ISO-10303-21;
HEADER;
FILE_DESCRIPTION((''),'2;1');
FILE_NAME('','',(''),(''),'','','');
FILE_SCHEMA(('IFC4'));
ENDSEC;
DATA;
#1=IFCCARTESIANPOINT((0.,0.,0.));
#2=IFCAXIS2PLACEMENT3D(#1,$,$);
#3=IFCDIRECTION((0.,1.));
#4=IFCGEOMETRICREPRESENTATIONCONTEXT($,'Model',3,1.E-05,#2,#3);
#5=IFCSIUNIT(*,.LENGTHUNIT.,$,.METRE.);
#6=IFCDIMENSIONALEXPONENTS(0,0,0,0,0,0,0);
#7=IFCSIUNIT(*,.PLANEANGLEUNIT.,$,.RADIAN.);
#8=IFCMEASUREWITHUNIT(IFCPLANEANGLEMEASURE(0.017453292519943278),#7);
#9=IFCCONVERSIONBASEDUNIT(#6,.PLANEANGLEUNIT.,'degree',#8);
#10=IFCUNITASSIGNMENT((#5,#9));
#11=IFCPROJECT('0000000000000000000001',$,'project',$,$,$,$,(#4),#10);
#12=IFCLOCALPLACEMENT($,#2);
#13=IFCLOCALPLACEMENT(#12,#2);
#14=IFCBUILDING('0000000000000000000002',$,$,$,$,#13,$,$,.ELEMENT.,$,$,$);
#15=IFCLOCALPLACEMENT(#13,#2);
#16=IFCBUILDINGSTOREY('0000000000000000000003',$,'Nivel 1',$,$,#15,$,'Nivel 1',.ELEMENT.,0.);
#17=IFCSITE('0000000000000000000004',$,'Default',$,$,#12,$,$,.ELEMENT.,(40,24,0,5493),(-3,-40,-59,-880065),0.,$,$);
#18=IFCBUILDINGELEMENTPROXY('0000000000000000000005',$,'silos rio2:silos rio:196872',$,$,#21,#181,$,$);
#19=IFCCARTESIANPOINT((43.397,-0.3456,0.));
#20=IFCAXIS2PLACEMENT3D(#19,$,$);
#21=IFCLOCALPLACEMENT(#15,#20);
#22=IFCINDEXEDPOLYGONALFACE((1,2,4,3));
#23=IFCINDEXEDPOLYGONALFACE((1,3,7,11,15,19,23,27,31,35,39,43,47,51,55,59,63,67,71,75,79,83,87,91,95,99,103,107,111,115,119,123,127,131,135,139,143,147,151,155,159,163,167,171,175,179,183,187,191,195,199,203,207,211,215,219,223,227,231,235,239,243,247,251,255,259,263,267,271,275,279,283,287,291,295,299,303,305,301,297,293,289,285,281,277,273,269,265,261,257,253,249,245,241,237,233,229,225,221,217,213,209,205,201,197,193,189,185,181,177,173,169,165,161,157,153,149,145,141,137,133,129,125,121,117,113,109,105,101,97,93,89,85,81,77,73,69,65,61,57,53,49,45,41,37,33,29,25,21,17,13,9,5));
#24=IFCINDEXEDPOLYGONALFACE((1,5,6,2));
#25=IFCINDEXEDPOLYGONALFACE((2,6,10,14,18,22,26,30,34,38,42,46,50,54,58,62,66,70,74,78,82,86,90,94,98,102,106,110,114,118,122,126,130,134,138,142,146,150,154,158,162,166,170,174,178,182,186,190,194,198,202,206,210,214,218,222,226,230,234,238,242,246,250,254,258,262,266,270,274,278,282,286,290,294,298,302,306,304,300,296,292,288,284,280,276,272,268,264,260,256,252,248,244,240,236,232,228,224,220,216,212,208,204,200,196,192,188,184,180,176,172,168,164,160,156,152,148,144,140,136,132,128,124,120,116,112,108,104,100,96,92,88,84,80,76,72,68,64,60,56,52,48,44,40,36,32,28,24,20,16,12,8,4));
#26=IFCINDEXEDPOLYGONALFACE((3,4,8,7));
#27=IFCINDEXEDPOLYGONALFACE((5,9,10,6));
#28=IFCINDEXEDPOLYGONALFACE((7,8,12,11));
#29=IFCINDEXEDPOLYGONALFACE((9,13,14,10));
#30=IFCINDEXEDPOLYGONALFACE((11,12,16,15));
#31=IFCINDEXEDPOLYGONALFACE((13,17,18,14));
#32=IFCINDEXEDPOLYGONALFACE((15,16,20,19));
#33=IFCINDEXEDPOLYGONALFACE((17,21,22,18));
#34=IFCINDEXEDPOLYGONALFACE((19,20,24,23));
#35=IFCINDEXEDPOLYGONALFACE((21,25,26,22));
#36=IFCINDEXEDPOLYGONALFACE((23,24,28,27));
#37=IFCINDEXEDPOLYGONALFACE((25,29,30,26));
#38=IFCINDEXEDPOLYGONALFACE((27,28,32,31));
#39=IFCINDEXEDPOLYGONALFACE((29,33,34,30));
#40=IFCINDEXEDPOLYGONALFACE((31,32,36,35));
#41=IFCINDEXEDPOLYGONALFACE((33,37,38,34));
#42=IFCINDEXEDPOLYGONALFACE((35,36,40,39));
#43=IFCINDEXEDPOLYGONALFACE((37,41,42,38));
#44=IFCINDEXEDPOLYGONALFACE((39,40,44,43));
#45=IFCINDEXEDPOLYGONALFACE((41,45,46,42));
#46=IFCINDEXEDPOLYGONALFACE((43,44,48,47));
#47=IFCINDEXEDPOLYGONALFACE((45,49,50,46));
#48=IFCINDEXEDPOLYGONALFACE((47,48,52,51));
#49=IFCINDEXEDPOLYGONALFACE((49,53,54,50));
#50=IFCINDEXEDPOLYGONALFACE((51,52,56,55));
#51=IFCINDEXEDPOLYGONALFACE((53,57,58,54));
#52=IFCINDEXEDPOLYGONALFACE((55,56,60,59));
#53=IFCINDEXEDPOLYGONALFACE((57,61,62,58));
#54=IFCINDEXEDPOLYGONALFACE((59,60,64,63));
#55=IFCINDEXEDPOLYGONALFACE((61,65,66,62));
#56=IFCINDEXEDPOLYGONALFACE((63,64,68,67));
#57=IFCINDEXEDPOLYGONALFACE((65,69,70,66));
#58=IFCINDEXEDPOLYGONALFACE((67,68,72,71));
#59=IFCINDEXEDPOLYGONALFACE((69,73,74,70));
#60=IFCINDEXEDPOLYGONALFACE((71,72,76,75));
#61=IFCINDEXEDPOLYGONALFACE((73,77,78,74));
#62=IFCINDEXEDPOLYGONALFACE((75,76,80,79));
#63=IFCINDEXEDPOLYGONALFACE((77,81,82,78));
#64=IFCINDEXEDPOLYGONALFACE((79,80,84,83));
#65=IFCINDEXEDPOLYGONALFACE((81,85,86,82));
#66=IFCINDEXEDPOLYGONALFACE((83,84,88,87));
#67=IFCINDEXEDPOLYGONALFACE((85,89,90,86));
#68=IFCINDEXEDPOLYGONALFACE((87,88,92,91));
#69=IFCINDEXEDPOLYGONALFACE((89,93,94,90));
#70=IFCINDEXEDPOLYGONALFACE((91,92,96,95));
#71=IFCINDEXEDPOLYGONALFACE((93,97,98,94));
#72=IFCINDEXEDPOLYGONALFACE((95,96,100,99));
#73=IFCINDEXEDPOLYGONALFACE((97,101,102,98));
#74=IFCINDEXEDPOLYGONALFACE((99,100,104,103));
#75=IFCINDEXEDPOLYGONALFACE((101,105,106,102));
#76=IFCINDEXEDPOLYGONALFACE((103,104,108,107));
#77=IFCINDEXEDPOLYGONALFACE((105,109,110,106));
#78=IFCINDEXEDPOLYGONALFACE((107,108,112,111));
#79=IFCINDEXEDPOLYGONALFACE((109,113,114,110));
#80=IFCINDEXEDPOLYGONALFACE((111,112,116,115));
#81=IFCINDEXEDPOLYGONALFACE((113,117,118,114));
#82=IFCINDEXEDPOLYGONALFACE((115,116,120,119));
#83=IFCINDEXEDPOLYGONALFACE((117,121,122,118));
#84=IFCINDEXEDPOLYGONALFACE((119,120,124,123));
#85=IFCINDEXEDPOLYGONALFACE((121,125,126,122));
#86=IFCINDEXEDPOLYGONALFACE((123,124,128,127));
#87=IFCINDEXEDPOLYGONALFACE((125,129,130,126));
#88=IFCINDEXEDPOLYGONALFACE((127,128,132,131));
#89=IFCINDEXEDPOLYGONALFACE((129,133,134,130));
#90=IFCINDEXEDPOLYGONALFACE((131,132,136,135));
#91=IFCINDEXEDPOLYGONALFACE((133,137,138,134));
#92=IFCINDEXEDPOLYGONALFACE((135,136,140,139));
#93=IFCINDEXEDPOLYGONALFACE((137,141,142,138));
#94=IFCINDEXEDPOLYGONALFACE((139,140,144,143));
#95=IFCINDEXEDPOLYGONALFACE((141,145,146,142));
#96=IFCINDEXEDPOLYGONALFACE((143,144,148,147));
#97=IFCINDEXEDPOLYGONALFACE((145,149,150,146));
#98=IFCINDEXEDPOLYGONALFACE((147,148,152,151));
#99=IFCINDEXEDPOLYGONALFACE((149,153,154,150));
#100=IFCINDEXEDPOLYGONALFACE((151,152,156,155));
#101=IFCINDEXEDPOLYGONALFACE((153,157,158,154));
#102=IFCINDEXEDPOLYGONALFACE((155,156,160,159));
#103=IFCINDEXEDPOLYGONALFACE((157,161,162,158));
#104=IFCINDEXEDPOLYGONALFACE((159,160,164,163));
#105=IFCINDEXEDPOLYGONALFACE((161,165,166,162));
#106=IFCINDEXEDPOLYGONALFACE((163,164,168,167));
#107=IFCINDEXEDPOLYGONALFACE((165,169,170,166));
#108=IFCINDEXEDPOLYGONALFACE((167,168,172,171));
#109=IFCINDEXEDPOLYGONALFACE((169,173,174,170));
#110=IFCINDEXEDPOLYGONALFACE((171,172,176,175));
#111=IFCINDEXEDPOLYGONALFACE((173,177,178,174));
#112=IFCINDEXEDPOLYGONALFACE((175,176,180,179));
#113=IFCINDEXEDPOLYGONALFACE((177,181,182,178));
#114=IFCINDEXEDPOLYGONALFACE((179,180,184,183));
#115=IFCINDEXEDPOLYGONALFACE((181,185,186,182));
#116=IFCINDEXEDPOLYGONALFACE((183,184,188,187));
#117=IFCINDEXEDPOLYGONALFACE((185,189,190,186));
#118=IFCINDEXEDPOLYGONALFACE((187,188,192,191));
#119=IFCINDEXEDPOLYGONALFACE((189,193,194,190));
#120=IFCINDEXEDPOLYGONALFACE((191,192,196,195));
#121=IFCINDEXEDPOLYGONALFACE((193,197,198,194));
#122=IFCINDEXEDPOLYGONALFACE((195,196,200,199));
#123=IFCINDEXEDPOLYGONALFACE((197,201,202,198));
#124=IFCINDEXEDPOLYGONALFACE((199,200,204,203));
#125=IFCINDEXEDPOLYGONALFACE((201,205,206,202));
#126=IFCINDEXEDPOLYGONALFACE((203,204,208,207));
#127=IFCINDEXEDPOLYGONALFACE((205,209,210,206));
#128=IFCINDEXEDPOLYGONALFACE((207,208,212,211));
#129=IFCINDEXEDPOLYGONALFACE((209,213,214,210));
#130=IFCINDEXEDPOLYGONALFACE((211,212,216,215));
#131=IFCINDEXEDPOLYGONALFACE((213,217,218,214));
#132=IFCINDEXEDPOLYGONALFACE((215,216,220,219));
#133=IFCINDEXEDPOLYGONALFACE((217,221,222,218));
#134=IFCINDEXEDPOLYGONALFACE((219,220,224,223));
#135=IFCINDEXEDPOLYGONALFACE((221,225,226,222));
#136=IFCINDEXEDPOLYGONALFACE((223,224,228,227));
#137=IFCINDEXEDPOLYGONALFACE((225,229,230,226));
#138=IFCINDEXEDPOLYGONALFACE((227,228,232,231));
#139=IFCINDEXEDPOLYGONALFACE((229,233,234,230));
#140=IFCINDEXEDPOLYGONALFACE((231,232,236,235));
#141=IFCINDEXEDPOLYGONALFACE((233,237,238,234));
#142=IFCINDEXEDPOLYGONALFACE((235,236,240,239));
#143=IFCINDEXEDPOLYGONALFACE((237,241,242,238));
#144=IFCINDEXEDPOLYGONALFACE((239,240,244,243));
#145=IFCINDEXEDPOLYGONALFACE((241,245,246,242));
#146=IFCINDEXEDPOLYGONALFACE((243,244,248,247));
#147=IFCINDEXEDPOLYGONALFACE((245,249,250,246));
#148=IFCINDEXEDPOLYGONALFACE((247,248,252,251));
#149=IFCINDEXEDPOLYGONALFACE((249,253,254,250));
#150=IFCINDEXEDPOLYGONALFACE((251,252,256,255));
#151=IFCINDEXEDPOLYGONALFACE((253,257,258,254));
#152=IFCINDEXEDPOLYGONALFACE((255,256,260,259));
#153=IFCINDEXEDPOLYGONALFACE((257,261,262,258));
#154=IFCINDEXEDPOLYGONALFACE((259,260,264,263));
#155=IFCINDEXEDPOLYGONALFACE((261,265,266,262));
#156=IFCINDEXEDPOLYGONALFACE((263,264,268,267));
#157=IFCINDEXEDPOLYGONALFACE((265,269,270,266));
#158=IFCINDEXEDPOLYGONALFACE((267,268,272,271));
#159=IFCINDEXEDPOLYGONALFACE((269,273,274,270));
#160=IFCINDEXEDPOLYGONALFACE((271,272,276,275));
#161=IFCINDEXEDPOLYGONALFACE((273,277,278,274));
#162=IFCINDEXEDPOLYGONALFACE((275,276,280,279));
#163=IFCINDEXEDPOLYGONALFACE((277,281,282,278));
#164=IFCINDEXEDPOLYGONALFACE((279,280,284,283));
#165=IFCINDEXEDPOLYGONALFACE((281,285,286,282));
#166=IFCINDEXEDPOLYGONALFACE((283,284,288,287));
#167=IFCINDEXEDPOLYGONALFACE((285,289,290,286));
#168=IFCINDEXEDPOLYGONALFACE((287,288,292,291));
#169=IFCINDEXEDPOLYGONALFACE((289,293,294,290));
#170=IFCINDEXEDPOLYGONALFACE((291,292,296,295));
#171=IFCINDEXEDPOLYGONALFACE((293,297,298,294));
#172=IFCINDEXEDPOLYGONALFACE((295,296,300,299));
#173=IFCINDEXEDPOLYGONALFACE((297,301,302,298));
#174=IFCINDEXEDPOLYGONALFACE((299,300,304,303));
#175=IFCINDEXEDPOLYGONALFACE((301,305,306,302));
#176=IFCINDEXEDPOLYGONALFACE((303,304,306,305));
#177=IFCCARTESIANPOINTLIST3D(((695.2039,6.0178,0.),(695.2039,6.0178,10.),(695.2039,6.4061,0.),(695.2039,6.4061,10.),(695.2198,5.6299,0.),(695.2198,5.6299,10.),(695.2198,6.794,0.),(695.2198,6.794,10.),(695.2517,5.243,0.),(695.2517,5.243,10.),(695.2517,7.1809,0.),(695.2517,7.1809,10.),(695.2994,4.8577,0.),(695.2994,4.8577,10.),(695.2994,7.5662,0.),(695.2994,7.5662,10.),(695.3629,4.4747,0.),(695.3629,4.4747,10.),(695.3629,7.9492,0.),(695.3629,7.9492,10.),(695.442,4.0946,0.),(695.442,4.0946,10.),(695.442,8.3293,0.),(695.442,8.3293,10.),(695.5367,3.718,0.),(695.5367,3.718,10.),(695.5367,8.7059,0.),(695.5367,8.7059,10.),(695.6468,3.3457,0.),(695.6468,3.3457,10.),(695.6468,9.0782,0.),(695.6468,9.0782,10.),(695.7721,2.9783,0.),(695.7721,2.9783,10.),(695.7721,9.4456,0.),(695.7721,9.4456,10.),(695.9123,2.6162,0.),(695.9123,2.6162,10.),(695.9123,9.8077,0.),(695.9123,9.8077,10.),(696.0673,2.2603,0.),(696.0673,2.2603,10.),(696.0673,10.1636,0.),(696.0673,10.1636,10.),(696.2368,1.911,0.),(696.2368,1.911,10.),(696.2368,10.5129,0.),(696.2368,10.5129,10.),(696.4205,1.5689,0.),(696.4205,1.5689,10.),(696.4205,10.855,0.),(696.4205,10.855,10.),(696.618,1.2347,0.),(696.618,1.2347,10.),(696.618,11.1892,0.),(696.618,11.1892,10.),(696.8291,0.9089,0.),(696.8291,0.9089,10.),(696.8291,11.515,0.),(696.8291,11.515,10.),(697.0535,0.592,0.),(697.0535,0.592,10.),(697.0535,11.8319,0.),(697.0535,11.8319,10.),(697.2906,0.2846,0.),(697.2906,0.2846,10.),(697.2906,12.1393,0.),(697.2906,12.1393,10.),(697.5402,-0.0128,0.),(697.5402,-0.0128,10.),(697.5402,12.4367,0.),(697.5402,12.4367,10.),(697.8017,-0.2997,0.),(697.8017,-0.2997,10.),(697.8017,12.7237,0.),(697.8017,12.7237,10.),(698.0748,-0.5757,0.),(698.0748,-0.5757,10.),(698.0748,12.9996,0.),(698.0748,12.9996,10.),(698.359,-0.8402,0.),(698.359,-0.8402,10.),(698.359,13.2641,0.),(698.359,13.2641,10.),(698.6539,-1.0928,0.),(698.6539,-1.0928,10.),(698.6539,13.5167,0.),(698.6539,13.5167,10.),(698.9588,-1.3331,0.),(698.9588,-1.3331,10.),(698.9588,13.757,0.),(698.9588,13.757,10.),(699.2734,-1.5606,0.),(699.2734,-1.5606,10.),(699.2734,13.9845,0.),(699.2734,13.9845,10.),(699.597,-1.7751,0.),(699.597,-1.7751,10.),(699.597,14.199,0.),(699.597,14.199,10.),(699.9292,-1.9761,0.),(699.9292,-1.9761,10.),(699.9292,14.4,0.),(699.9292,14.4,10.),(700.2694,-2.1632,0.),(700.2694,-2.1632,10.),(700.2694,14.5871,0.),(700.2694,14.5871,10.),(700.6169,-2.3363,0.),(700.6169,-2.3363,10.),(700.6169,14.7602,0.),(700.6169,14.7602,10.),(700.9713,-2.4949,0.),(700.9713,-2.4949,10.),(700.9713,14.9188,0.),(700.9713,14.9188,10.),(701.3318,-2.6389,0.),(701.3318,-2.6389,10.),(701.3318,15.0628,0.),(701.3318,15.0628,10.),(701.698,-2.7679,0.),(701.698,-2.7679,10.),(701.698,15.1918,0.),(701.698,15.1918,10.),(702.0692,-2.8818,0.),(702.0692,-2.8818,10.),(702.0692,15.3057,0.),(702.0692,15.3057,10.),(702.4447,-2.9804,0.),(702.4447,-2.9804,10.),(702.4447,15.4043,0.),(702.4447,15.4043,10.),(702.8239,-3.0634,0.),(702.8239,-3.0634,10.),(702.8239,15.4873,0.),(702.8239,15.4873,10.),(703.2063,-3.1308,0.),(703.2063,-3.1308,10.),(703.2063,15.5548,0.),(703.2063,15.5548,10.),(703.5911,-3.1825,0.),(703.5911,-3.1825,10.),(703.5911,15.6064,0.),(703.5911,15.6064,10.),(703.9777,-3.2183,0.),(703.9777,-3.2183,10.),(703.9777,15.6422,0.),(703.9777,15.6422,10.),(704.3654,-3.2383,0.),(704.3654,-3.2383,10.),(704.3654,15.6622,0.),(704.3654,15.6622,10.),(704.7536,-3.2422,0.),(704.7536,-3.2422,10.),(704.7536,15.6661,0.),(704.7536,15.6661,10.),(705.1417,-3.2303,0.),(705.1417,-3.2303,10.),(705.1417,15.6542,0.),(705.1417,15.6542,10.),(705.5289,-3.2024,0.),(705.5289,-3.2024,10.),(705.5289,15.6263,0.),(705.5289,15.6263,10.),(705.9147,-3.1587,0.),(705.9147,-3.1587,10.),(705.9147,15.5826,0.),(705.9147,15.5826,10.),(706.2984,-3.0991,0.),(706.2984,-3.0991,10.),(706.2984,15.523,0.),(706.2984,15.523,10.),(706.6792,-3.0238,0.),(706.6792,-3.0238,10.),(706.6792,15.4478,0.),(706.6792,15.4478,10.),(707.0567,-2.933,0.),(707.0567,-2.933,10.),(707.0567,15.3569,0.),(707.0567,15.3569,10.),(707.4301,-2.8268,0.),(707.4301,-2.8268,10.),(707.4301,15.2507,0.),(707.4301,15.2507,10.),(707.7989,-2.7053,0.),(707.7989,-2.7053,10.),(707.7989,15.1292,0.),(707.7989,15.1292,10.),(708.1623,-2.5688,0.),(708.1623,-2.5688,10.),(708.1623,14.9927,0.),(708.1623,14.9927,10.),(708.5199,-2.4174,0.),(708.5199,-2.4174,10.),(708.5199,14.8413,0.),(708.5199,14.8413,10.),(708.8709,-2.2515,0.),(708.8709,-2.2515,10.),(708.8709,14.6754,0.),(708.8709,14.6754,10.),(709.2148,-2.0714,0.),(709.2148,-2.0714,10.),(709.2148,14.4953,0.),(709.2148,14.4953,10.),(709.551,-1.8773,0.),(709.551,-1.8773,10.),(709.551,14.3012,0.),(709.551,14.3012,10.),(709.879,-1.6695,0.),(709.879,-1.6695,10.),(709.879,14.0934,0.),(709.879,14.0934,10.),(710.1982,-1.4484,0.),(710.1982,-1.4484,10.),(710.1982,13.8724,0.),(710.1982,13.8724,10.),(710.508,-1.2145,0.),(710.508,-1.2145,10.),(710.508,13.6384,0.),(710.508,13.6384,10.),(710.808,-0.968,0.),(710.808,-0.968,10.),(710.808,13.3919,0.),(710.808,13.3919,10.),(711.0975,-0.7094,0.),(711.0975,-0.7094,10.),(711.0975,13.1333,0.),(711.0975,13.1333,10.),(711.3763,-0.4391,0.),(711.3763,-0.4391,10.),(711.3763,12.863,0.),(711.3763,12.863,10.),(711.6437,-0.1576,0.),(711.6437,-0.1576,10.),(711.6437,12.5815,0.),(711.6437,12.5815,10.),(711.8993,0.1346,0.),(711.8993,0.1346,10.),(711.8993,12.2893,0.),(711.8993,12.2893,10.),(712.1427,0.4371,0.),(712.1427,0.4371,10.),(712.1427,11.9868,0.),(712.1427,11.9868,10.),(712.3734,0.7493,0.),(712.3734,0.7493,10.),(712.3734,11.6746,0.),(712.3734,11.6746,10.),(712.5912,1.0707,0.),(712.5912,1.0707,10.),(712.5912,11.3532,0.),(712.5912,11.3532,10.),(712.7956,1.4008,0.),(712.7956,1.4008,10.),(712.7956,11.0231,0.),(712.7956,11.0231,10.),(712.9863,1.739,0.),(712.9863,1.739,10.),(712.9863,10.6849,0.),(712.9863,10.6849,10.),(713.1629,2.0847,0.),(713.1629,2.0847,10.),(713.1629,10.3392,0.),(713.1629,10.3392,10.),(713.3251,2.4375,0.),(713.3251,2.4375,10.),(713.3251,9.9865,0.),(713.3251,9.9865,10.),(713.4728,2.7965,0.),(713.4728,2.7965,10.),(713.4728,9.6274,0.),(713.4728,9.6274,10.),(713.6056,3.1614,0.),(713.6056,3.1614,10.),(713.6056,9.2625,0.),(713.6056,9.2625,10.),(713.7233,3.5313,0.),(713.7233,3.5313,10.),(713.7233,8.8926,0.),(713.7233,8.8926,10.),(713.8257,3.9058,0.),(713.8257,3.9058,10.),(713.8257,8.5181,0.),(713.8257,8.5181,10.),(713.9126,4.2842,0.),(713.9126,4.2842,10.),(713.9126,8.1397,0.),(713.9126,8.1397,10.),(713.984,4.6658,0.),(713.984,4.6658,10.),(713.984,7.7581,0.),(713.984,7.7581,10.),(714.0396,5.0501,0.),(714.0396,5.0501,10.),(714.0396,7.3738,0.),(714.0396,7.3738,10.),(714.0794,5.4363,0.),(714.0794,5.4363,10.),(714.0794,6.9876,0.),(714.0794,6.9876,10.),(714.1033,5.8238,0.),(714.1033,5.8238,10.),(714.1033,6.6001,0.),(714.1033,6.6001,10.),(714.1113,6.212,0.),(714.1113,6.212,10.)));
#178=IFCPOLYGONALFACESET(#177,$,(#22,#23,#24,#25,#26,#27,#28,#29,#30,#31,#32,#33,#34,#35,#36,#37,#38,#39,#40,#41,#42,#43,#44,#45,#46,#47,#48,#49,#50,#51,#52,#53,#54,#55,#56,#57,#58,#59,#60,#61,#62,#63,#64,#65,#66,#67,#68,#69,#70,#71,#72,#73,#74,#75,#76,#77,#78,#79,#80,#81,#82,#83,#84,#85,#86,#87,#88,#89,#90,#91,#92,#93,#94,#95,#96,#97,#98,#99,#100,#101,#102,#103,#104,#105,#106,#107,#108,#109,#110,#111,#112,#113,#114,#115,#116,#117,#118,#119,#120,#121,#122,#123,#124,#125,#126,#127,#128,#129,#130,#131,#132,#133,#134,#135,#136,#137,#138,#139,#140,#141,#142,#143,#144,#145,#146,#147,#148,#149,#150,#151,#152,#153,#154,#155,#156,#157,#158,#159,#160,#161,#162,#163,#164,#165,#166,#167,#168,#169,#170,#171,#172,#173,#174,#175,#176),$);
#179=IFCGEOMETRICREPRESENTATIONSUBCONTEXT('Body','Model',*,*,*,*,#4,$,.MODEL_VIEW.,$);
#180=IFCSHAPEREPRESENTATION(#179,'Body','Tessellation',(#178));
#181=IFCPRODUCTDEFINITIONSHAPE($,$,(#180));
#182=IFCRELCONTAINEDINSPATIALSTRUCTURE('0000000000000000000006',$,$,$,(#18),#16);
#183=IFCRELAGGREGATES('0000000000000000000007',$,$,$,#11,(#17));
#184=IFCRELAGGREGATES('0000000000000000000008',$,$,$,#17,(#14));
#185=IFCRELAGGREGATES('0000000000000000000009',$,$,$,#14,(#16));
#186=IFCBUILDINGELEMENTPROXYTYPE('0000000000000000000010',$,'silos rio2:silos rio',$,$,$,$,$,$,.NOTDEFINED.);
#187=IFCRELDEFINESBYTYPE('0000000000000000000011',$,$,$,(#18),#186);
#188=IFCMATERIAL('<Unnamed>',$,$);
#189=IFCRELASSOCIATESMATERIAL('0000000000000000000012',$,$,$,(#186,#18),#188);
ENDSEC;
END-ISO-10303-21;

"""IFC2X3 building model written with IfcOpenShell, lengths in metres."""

from ifc_helpers import new_model, entity, si_unit, converted_unit, direction, frame, frame_2d, origin, place, context, subcontext, project, spatial, circle, extrude, source, transform, mapped, material, type_object, type_shapes, element, save


model = new_model("IFC2X3")

# Units and contexts
model_context = context("Model", 3, precision=1e-05, world=origin(), true_north=direction((0.0, 1.0)))
body_context = subcontext(model_context, "Body", "Model", "MODEL_VIEW")
ifc_project = project(units=[si_unit("LENGTHUNIT", "METRE"), converted_unit("PLANEANGLEUNIT", "degree", entity("IfcPlaneAngleMeasure", 0.017453292519943278), si_unit("PLANEANGLEUNIT", "RADIAN"), dimensions=[0, 0, 0, 0, 0, 0, 0])], contexts=[model_context])

# Site, building, storey
site_placement = place(None, origin())
site = spatial("IfcSite", under=ifc_project, at=site_placement, Name="Default", CompositionType="ELEMENT", RefLatitude=(40, 24, 0, 5493), RefLongitude=(-3, -40, -59, -880065), RefElevation=0.0)
building_placement = place(site_placement, origin())
building = spatial("IfcBuilding", under=site, at=building_placement, CompositionType="ELEMENT")
storey_placement = place(building_placement, origin())
storey = spatial("IfcBuildingStorey", under=building, at=storey_placement, Name="Nivel 1", LongName="Nivel 1", CompositionType="ELEMENT", Elevation=0.0)

# Building element proxy
ifc_material_1 = material(Name="<Unnamed>")
building_element_proxy_type_1 = type_object("IfcBuildingElementProxyType", Name="silos rio2:silos rio", PredefinedType="NOTDEFINED", material=ifc_material_1)
shared_shape_1 = source(origin(), body_context, "Body", "SweptSolid", [
    extrude(circle(Radius=9.4547, at=frame_2d((0.0, 0.0), x_axis=(1.0, 0.0))), frame((704.6566, 6.212, 0.0)), (0.0, 0.0, 1.0), 10.0),
])
type_shapes(building_element_proxy_type_1, [shared_shape_1])
proxy_1_placement = place(storey_placement, frame((43.397, -0.3456, 0.0)))
element("IfcBuildingElementProxy", 1, at=proxy_1_placement, inside=storey, type_object=building_element_proxy_type_1, material=ifc_material_1, Name="silos rio2:silos rio:196872", context=body_context, shape_type="MappedRepresentation", body=[
    mapped(shared_shape_1, transform((0.0, 0.0, 0.0), scale=1.0)),
])

save(model, "model.ifc")
